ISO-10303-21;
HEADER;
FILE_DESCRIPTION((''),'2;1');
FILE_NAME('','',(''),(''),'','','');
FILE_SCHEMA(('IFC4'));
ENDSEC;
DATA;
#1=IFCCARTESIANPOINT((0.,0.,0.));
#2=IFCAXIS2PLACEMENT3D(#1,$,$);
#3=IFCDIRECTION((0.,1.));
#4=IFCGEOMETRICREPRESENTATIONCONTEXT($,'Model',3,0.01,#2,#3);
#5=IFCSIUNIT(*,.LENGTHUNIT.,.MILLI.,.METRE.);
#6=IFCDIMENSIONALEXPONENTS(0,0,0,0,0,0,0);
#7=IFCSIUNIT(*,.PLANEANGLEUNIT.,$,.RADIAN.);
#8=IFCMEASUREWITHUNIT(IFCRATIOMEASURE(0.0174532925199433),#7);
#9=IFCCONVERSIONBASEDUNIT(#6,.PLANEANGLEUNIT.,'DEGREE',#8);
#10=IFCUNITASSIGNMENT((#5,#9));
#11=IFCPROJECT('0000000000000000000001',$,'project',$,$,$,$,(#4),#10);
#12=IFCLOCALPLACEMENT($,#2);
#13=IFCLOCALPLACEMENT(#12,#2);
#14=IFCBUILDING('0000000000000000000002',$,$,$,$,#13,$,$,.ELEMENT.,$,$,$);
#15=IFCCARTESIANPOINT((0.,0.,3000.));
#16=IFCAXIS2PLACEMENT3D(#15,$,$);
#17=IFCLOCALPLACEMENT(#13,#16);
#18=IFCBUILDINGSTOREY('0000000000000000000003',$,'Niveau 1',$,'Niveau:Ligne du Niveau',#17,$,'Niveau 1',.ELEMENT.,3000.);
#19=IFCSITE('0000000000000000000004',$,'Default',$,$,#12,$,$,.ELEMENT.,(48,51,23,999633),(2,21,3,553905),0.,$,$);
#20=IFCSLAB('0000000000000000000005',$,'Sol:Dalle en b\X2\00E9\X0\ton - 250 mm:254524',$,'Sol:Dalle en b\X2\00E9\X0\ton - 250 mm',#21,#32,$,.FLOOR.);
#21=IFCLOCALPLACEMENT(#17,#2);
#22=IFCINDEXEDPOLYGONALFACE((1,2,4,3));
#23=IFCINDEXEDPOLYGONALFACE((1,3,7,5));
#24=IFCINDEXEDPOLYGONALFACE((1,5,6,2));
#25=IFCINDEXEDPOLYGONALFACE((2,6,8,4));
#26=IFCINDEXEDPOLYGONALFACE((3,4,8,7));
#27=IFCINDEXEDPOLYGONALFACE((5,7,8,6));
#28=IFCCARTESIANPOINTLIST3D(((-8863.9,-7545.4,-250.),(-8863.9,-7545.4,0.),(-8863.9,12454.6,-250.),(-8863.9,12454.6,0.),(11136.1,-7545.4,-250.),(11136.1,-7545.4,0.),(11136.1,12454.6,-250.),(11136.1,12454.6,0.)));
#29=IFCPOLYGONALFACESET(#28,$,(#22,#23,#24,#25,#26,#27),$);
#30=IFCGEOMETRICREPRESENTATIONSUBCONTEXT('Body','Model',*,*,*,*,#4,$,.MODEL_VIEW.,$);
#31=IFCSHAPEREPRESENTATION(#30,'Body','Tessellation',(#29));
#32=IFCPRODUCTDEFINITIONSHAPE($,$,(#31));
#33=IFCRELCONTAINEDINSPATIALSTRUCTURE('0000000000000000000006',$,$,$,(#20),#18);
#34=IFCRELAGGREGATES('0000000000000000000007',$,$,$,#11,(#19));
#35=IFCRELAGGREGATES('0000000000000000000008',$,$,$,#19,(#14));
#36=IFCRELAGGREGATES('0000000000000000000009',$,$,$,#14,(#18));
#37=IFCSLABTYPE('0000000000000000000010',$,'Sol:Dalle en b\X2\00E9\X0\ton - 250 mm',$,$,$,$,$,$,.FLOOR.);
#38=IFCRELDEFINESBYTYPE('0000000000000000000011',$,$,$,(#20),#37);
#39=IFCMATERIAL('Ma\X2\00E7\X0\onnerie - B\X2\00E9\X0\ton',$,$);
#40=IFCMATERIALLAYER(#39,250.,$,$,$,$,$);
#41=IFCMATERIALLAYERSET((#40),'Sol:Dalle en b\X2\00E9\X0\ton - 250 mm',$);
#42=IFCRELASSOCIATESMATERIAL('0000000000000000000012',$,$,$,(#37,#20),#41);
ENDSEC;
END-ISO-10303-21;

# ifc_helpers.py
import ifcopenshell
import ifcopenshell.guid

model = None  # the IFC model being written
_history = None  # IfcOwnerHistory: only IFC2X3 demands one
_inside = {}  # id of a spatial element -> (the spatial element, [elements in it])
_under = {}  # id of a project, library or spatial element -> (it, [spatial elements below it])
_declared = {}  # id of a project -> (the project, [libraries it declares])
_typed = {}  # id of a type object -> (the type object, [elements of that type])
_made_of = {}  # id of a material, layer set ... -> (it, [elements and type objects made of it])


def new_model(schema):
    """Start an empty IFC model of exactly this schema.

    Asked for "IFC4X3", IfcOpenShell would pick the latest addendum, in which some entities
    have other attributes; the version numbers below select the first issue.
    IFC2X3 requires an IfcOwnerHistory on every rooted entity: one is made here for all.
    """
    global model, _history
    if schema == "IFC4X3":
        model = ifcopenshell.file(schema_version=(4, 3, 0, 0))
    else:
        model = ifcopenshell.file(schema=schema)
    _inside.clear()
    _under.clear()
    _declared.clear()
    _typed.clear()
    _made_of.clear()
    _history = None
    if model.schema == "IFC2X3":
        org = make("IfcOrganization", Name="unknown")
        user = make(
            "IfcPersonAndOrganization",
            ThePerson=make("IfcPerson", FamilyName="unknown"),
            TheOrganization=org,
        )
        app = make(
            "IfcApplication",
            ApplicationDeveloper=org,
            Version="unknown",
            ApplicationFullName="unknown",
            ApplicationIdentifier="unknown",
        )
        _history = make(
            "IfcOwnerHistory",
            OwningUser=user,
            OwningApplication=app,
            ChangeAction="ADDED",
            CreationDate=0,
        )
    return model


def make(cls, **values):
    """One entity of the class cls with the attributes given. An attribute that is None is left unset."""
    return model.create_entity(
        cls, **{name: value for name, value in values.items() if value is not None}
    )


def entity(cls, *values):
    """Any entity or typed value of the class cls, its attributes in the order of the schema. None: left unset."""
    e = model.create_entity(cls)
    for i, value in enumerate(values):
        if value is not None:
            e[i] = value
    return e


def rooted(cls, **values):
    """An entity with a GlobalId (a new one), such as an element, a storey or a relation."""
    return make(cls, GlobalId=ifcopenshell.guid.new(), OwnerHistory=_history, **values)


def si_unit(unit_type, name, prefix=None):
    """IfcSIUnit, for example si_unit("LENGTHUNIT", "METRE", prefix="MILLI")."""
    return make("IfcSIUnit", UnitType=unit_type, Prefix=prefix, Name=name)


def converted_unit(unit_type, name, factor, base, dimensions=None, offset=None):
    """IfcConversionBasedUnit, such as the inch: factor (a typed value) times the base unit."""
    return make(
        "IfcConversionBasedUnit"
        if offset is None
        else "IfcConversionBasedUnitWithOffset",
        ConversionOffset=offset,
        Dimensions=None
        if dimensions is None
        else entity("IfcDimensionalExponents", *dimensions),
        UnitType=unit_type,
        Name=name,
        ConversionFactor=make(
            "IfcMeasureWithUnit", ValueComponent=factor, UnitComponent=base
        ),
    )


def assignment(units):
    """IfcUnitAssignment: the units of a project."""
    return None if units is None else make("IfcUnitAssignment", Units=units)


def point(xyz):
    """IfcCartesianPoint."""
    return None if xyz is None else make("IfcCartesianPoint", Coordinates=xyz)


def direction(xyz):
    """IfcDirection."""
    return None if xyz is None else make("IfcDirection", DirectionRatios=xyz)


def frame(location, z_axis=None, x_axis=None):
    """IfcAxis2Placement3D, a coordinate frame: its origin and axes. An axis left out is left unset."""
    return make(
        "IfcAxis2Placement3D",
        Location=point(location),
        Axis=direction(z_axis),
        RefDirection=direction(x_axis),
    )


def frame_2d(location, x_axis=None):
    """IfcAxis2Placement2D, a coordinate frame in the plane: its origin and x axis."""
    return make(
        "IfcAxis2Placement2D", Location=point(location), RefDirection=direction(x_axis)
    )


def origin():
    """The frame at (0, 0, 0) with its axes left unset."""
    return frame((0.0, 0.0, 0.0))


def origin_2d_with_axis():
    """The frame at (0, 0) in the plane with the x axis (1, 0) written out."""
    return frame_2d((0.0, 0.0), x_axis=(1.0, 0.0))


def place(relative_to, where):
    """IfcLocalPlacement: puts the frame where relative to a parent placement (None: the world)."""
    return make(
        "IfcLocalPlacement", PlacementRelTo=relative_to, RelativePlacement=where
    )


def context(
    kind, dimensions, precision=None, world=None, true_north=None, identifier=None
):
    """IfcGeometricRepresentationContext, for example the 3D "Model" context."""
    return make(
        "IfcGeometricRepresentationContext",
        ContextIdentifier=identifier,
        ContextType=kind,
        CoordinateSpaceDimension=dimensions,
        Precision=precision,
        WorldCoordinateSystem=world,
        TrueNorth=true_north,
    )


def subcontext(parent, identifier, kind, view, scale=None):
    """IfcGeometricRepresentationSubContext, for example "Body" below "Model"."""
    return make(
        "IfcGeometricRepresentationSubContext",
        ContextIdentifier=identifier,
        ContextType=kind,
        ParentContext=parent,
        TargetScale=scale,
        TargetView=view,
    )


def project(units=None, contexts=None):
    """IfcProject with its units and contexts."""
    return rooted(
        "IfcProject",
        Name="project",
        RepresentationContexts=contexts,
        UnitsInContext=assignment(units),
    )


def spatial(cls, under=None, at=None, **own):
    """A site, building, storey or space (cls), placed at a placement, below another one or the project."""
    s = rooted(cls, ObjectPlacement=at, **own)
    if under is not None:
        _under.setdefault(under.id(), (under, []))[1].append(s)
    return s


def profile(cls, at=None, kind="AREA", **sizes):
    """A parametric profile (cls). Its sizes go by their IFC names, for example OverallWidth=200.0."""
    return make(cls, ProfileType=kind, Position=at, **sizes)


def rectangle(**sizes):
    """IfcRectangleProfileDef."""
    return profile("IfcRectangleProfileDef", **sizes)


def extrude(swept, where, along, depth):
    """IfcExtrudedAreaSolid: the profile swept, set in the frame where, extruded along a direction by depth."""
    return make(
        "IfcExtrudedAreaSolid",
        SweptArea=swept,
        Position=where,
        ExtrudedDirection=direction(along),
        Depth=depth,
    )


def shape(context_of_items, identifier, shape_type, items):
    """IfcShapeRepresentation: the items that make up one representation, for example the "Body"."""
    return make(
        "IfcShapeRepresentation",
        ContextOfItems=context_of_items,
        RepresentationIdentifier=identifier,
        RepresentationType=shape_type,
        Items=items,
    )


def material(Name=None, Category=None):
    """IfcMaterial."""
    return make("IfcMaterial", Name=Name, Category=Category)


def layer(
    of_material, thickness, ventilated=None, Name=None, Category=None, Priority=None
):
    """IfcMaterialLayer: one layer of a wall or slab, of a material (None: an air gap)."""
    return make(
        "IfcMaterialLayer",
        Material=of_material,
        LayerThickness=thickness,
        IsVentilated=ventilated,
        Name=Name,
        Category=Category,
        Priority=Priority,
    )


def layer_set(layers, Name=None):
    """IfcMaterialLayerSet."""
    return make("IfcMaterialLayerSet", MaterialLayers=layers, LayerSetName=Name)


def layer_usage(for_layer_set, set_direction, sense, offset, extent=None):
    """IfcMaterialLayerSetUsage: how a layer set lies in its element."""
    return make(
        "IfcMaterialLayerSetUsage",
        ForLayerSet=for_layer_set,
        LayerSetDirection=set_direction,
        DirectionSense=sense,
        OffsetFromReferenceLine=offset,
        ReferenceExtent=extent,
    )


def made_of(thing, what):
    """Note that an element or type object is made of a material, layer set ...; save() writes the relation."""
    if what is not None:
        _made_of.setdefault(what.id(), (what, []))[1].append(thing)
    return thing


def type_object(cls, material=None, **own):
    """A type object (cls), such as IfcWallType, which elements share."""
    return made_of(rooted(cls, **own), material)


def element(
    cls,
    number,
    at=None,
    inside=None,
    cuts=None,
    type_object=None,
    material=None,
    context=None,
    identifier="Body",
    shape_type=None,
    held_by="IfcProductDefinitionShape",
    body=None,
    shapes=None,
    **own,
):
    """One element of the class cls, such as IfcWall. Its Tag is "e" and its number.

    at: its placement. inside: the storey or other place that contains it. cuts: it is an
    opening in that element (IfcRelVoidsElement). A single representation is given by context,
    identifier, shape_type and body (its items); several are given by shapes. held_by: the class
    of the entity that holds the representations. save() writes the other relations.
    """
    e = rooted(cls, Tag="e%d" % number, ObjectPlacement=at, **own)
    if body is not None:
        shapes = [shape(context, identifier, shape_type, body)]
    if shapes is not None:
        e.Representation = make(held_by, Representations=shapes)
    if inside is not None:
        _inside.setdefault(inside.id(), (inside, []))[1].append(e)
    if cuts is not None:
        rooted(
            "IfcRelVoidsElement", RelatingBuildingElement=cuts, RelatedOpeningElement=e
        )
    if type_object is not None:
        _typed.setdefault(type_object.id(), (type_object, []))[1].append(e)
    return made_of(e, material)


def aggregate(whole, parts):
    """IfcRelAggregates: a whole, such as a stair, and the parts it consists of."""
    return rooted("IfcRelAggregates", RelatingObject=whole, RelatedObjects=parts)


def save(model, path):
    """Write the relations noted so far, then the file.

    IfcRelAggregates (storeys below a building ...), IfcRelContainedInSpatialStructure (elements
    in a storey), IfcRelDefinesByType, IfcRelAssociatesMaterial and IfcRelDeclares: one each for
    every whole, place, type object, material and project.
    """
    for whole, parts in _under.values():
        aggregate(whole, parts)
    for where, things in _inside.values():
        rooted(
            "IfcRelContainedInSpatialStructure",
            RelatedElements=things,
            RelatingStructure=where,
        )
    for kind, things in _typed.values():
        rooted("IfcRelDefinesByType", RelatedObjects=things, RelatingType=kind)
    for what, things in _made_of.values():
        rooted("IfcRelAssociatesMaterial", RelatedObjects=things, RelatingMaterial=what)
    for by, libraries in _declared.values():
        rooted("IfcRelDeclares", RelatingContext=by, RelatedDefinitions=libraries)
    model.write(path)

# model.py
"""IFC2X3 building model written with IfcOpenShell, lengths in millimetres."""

from ifc_helpers import new_model, entity, si_unit, converted_unit, direction, frame, origin, origin_2d_with_axis, place, context, subcontext, project, spatial, rectangle, extrude, material, layer, layer_set, layer_usage, type_object, element, save


model = new_model("IFC2X3")

# Units and contexts
model_context = context("Model", 3, precision=0.01, world=origin(), true_north=direction((0.0, 1.0)))
body_context = subcontext(model_context, "Body", "Model", "MODEL_VIEW")
ifc_project = project(units=[si_unit("LENGTHUNIT", "METRE", prefix="MILLI"), converted_unit("PLANEANGLEUNIT", "DEGREE", entity("IfcRatioMeasure", 0.0174532925199433), si_unit("PLANEANGLEUNIT", "RADIAN"), dimensions=[0, 0, 0, 0, 0, 0, 0])], contexts=[model_context])

# Site, building, storey
site_placement = place(None, origin())
site = spatial("IfcSite", under=ifc_project, at=site_placement, Name="Default", CompositionType="ELEMENT", RefLatitude=(48, 51, 23, 999633), RefLongitude=(2, 21, 3, 553905), RefElevation=0.0)
building_placement = place(site_placement, origin())
building = spatial("IfcBuilding", under=site, at=building_placement, CompositionType="ELEMENT")
storey_placement = place(building_placement, frame((0.0, 0.0, 3000.0)))
storey = spatial("IfcBuildingStorey", under=building, at=storey_placement, Name="Niveau 1", ObjectType="Niveau:Ligne du Niveau", LongName="Niveau 1", CompositionType="ELEMENT", Elevation=3000.0)

# Slab
ifc_material = material(Name="Maçonnerie - Béton")
ifc_layer = layer(ifc_material, 250.0)
ifc_layer_set = layer_set([ifc_layer], Name="Sol:Dalle en béton - 250 mm")
ifc_layer_usage = layer_usage(ifc_layer_set, "AXIS3", "POSITIVE", 0.0)
slab_type = type_object("IfcSlabType", Name="Sol:Dalle en béton - 250 mm", PredefinedType="FLOOR", material=ifc_layer_set)
slab_placement = place(storey_placement, origin())
element("IfcSlab", 1, at=slab_placement, inside=storey, type_object=slab_type, material=ifc_layer_usage, Name="Sol:Dalle en béton - 250 mm:254524", ObjectType="Sol:Dalle en béton - 250 mm", PredefinedType="FLOOR", context=body_context, shape_type="SweptSolid", body=[
    extrude(rectangle(XDim=20000.0, YDim=20000.0, at=origin_2d_with_axis()), frame((1136.1, 2454.6, 0.0), z_axis=(0.0, 0.0, -1.0), x_axis=(0.0, 1.0, 0.0)), (0.0, 0.0, 1.0), 250.0),
])

save(model, "model.ifc")
